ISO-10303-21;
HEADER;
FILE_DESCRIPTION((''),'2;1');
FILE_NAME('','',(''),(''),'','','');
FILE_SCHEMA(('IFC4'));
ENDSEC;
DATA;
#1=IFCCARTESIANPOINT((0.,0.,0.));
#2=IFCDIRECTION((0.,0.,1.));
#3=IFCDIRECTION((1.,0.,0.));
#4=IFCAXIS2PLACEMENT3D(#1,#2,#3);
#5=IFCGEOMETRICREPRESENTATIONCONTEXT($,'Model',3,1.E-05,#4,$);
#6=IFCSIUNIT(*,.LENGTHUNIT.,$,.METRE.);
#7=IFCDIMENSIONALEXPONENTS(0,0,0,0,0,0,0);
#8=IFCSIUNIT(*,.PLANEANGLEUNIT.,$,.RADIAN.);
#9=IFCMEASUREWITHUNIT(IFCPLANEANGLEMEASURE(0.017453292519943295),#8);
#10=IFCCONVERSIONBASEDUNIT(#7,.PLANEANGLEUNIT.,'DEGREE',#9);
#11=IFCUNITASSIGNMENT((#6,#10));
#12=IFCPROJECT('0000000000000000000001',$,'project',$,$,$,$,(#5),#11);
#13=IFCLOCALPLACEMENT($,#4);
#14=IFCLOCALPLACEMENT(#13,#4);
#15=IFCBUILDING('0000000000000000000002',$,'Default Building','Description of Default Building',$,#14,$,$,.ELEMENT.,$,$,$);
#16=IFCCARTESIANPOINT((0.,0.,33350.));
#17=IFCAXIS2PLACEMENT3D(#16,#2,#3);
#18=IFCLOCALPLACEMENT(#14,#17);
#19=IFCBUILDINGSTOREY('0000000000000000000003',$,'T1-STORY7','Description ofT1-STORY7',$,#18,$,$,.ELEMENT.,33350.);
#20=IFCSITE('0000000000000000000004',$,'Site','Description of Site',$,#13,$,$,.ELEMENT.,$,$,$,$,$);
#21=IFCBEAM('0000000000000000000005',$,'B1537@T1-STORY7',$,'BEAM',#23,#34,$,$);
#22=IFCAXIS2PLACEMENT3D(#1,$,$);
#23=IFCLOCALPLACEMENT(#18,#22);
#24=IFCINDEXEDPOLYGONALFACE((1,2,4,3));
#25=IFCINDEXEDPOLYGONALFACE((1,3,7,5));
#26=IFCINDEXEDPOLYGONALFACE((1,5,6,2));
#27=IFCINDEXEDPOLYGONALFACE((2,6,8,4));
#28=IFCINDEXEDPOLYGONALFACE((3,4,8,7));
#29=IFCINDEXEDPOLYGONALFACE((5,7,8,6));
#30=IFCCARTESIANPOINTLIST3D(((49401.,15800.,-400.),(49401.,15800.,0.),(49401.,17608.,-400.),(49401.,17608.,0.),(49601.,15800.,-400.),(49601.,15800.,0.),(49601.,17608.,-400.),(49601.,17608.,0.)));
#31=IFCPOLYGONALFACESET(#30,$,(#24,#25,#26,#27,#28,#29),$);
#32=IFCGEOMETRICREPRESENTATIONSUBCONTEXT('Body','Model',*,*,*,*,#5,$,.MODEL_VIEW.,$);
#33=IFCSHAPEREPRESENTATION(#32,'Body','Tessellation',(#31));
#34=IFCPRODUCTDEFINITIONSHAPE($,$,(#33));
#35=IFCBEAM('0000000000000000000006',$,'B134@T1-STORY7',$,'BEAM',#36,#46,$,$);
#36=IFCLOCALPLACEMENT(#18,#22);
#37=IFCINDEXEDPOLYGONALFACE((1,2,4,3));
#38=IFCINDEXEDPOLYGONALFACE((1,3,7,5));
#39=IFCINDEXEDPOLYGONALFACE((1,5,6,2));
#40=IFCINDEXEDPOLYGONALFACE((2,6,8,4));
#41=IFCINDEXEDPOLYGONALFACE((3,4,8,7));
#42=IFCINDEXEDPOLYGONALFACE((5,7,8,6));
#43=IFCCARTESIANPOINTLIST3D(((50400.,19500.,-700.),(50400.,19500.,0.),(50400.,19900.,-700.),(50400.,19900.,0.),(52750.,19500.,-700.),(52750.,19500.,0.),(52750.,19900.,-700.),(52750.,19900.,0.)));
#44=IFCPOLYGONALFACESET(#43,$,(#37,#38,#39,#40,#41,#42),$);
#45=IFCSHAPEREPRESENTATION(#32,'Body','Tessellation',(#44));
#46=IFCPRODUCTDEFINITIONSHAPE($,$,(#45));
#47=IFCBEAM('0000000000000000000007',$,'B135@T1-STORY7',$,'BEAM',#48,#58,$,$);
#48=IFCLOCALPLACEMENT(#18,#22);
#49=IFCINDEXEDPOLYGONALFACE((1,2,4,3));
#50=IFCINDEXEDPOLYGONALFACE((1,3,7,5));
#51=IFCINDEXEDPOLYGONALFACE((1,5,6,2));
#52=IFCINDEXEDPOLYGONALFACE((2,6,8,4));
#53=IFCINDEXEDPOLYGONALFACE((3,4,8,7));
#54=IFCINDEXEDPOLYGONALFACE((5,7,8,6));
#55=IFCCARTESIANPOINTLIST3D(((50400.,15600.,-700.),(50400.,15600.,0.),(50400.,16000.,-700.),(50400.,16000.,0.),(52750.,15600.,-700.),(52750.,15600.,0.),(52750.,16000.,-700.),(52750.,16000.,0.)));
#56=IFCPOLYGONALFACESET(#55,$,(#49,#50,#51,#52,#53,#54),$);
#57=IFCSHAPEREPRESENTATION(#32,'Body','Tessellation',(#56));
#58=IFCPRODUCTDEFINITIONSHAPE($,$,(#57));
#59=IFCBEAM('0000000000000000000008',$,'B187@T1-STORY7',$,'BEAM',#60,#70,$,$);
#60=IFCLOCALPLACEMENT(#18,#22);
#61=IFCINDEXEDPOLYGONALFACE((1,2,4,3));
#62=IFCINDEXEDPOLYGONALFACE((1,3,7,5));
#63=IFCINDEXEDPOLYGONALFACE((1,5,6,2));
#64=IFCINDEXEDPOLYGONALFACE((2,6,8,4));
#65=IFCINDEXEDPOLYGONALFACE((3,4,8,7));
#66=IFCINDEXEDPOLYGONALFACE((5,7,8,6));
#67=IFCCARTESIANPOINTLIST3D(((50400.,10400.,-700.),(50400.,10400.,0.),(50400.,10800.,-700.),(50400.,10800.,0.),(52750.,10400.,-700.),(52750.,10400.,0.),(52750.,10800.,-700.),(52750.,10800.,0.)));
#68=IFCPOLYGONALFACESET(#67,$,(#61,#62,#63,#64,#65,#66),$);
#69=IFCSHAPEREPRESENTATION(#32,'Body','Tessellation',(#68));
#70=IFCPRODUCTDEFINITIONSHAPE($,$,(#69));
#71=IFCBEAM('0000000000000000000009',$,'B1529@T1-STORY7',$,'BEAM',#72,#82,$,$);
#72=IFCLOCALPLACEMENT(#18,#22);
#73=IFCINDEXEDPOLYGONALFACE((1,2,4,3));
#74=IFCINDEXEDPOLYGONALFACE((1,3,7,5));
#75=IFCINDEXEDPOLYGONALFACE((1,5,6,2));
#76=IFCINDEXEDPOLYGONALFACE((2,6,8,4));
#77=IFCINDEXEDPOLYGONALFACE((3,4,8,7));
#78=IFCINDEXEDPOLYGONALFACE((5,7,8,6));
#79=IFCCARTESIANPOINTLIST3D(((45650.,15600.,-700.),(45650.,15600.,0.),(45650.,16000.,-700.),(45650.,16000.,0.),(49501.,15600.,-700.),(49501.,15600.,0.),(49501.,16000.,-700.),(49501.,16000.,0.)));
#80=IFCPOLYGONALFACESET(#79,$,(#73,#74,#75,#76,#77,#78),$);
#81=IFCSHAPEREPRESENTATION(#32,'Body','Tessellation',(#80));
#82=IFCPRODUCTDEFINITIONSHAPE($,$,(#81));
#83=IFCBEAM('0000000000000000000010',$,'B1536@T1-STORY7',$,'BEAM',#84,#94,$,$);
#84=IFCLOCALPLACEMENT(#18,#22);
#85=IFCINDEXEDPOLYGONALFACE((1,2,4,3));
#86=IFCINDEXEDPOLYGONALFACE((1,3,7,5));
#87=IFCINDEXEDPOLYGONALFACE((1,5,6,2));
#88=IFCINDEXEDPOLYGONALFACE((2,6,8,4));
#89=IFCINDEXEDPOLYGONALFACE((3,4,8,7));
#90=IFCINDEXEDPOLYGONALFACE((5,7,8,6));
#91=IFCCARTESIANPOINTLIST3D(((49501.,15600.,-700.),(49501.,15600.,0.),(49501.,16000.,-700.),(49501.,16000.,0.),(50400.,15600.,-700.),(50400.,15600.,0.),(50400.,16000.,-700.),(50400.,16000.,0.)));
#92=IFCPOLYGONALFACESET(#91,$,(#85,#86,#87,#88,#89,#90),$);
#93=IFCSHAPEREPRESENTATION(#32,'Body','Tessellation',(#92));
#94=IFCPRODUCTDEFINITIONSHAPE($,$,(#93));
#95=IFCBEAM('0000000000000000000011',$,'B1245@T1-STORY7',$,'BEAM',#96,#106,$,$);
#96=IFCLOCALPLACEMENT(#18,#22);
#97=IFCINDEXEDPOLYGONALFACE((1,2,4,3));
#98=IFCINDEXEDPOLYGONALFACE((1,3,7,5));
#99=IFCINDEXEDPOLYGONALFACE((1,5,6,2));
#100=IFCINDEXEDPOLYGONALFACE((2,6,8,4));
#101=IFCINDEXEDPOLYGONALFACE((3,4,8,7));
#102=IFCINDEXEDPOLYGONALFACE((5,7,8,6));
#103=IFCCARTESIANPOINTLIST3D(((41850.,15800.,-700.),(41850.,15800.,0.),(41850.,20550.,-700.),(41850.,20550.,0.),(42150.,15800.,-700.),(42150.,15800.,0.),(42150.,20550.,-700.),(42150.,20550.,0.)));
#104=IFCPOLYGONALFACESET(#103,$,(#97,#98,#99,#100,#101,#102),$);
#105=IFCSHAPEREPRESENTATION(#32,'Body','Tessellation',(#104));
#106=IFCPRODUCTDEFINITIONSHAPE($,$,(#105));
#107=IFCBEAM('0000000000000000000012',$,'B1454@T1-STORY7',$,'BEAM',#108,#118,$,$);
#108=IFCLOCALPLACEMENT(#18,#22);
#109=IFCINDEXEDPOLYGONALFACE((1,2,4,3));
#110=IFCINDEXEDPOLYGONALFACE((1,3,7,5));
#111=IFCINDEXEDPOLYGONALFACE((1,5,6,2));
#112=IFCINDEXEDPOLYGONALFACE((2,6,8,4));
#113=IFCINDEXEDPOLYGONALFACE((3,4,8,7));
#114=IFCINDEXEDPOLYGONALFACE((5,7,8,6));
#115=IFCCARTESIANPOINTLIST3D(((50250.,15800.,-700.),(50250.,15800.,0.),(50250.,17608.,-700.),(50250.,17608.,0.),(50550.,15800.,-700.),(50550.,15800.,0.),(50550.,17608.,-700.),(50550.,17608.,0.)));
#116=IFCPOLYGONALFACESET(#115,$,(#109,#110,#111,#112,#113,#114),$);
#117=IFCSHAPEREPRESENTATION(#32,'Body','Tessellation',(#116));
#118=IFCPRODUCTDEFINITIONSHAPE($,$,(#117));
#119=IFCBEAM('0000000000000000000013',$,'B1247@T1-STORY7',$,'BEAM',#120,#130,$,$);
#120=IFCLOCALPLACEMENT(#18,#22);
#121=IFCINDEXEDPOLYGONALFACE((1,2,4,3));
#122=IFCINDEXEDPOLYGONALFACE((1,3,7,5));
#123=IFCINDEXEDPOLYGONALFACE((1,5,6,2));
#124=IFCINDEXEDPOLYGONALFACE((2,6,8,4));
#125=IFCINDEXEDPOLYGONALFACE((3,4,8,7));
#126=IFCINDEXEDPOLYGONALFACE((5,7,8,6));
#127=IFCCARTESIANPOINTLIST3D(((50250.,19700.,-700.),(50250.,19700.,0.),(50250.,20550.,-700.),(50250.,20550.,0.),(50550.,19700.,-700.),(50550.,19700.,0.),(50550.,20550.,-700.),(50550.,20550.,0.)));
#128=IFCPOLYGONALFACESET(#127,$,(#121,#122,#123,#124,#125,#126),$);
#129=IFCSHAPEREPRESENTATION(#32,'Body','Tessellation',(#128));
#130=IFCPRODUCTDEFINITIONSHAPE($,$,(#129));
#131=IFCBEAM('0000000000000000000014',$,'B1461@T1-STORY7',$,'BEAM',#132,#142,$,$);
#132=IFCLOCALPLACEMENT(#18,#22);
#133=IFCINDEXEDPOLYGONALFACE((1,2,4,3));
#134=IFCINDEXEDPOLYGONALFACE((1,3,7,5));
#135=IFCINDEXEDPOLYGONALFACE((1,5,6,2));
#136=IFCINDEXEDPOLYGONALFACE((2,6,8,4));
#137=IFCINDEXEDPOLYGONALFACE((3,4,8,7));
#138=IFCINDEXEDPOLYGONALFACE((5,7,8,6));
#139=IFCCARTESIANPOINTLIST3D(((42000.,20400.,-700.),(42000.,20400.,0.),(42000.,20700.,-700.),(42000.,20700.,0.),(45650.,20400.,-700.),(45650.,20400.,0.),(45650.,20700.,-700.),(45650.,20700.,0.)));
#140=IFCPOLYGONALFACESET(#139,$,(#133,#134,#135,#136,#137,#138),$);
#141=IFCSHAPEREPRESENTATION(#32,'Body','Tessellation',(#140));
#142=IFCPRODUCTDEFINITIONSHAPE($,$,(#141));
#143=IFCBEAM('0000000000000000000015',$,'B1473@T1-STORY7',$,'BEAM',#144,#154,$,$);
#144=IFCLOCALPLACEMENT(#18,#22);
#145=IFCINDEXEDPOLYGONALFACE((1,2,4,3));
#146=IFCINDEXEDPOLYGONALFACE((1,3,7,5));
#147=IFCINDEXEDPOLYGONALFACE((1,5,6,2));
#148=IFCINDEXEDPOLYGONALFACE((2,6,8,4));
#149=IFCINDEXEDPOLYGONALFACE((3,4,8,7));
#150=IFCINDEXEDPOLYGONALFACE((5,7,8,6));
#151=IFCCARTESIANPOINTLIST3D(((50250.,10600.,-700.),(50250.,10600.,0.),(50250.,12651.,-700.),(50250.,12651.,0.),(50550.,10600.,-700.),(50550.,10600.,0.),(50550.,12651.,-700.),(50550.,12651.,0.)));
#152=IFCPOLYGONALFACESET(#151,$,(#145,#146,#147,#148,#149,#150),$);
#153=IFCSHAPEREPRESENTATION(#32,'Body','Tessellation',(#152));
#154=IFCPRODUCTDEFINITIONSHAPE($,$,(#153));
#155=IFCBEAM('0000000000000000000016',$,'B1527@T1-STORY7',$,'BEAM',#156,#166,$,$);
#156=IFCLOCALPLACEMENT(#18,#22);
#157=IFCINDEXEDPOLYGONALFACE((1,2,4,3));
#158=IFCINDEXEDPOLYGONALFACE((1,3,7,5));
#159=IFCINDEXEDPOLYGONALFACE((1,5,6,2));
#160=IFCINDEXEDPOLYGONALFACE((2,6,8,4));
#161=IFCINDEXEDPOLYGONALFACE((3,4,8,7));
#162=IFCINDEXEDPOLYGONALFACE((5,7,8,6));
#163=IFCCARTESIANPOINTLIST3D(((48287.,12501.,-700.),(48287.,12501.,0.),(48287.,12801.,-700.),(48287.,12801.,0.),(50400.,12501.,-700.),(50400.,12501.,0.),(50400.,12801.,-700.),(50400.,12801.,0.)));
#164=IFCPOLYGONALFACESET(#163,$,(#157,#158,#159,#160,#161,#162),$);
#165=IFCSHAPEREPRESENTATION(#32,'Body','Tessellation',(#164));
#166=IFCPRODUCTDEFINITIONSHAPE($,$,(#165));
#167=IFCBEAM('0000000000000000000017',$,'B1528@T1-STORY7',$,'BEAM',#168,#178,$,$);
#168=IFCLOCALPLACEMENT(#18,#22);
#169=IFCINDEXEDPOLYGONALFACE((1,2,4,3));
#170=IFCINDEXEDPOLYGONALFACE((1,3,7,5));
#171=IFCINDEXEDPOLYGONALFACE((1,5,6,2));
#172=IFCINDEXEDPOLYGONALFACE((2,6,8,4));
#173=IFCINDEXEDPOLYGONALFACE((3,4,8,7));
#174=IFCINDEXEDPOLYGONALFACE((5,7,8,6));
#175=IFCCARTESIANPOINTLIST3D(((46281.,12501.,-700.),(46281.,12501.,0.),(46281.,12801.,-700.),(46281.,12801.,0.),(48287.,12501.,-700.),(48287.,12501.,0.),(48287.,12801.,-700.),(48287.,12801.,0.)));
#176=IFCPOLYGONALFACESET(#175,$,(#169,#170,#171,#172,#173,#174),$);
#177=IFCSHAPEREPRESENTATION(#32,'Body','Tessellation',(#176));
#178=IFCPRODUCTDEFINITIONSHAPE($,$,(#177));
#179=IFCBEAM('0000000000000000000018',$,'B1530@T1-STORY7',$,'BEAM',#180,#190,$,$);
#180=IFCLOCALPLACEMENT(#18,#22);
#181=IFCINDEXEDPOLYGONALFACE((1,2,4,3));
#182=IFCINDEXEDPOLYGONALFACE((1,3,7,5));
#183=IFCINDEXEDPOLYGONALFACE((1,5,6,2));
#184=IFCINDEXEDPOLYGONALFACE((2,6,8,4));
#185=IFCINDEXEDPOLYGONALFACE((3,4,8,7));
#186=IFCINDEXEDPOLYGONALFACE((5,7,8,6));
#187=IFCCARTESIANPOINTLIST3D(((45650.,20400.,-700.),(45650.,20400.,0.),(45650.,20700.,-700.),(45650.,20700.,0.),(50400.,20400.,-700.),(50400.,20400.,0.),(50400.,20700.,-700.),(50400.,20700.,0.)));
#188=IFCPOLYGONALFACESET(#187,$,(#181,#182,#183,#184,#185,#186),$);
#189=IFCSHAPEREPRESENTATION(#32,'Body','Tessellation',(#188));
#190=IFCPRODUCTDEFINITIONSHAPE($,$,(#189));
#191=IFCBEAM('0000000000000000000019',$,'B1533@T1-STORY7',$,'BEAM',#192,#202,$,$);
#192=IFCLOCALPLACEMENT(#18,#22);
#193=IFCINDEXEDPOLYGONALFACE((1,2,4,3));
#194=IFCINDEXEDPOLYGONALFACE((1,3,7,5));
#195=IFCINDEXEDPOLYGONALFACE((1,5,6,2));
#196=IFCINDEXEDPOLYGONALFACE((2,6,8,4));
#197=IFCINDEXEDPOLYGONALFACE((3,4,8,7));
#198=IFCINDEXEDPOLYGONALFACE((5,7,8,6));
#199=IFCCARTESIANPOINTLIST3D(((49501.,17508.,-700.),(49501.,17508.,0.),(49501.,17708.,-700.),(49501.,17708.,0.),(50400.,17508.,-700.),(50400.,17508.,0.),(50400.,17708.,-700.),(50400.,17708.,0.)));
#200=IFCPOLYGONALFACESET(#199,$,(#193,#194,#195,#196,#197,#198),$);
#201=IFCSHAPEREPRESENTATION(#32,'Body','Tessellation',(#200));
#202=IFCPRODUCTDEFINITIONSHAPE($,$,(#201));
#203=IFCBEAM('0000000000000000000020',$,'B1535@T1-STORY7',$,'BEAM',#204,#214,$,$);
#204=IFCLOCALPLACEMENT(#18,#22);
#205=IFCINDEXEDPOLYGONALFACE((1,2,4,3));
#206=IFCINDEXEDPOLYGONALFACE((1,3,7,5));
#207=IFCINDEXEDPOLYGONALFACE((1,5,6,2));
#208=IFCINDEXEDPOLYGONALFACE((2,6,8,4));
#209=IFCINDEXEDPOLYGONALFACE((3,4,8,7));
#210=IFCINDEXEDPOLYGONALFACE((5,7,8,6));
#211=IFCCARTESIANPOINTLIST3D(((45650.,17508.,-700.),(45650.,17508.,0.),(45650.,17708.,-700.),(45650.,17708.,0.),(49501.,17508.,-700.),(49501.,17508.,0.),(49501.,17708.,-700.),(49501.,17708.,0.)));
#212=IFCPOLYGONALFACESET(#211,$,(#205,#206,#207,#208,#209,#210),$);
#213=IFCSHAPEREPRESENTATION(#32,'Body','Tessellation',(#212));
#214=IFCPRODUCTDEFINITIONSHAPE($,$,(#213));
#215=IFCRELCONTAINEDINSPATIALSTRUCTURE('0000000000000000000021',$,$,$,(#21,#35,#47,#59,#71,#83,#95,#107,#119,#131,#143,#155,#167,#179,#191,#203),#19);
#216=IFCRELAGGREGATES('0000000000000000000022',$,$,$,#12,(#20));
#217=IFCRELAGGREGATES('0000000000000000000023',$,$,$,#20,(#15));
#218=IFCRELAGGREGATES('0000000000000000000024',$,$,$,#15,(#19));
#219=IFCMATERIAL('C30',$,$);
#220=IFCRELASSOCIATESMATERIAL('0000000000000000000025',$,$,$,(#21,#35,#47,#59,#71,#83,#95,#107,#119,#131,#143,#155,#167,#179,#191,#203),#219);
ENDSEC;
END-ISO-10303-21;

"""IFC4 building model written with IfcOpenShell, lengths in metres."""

from ifc_helpers import new_model, entity, si_unit, converted_unit, frame, origin_with_axes, place, context, subcontext, project, spatial, rectangle, extrude, material, element, save


model = new_model("IFC4")

# Units and contexts
model_context = context("Model", 3, precision=1e-05, world=origin_with_axes())
body_context = subcontext(model_context, "Body", "Model", "MODEL_VIEW")
ifc_project = project(units=[si_unit("LENGTHUNIT", "METRE"), converted_unit("PLANEANGLEUNIT", "DEGREE", entity("IfcPlaneAngleMeasure", 0.017453292519943295), si_unit("PLANEANGLEUNIT", "RADIAN"), dimensions=[0, 0, 0, 0, 0, 0, 0])], contexts=[model_context])

# Site, building, storey
site_placement = place(None, origin_with_axes())
site = spatial("IfcSite", under=ifc_project, at=site_placement, Name="Site", Description="Description of Site", CompositionType="ELEMENT")
building_placement = place(site_placement, origin_with_axes())
building = spatial("IfcBuilding", under=site, at=building_placement, Name="Default Building", Description="Description of Default Building", CompositionType="ELEMENT")
storey_placement = place(building_placement, frame((0.0, 0.0, 33350.0), z_axis=(0.0, 0.0, 1.0), x_axis=(1.0, 0.0, 0.0)))
storey = spatial("IfcBuildingStorey", under=building, at=storey_placement, Name="T1-STORY7", Description="Description ofT1-STORY7", CompositionType="ELEMENT", Elevation=33350.0)

# Beams
ifc_material_1 = material(Name="C30")
beam_1_placement = place(storey_placement, frame((49501.0, 15800.0, -200.0), z_axis=(0.0, 1.0, 0.0), x_axis=(-1.0, 0.0, 0.0)))
element("IfcBeam", 1, at=beam_1_placement, inside=storey, material=ifc_material_1, Name="B1537@T1-STORY7", ObjectType="BEAM", context=body_context, shape_type="SweptSolid", body=[
    extrude(rectangle(XDim=200.0, YDim=400.0), origin_with_axes(), (0.0, 0.0, 1.0), 1808.0),
])
for number, where, z_axis, x_axis, name in (
    (2, (50400.0, 19700.0, -350.0), (1.0, 0.0, 0.0), (0.0, 1.0, 0.0), "B134@T1-STORY7"),
    (3, (50400.0, 15800.0, -350.0), (1.0, 0.0, 0.0), (0.0, 1.0, 0.0), "B135@T1-STORY7"),
    (4, (50400.0, 10600.0, -350.0), (1.0, 0.0, 0.0), (0.0, 1.0, 0.0), "B187@T1-STORY7"),
):
    element("IfcBeam", number, at=place(storey_placement, frame(where, z_axis=z_axis, x_axis=x_axis)), inside=storey, material=ifc_material_1, Name=name, ObjectType="BEAM", context=body_context, shape_type="SweptSolid", body=[
        extrude(rectangle(XDim=400.0, YDim=700.0), origin_with_axes(), (0.0, 0.0, 1.0), 2350.0),
    ])
beam_2_placement = place(storey_placement, frame((45650.0, 15800.0, -350.0), z_axis=(1.0, 0.0, 0.0), x_axis=(0.0, 1.0, 0.0)))
element("IfcBeam", 5, at=beam_2_placement, inside=storey, material=ifc_material_1, Name="B1529@T1-STORY7", ObjectType="BEAM", context=body_context, shape_type="SweptSolid", body=[
    extrude(rectangle(XDim=400.0, YDim=700.0), origin_with_axes(), (0.0, 0.0, 1.0), 3851.0),
])
beam_3_placement = place(storey_placement, frame((49501.0, 15800.0, -350.0), z_axis=(1.0, 0.0, 0.0), x_axis=(0.0, 1.0, 0.0)))
element("IfcBeam", 6, at=beam_3_placement, inside=storey, material=ifc_material_1, Name="B1536@T1-STORY7", ObjectType="BEAM", context=body_context, shape_type="SweptSolid", body=[
    extrude(rectangle(XDim=400.0, YDim=700.0), origin_with_axes(), (0.0, 0.0, 1.0), 899.0),
])
beam_4_placement = place(storey_placement, frame((42000.0, 15800.0, -350.0), z_axis=(0.0, 1.0, 0.0), x_axis=(-1.0, 0.0, 0.0)))
element("IfcBeam", 7, at=beam_4_placement, inside=storey, material=ifc_material_1, Name="B1245@T1-STORY7", ObjectType="BEAM", context=body_context, shape_type="SweptSolid", body=[
    extrude(rectangle(XDim=300.0, YDim=700.0), origin_with_axes(), (0.0, 0.0, 1.0), 4750.0),
])
beam_5_placement = place(storey_placement, frame((50400.0, 15800.0, -350.0), z_axis=(0.0, 1.0, 0.0), x_axis=(-1.0, 0.0, 0.0)))
element("IfcBeam", 8, at=beam_5_placement, inside=storey, material=ifc_material_1, Name="B1454@T1-STORY7", ObjectType="BEAM", context=body_context, shape_type="SweptSolid", body=[
    extrude(rectangle(XDim=300.0, YDim=700.0), origin_with_axes(), (0.0, 0.0, 1.0), 1808.0),
])
beam_6_placement = place(storey_placement, frame((50400.0, 19700.0, -350.0), z_axis=(0.0, 1.0, 0.0), x_axis=(-1.0, 0.0, 0.0)))
element("IfcBeam", 9, at=beam_6_placement, inside=storey, material=ifc_material_1, Name="B1247@T1-STORY7", ObjectType="BEAM", context=body_context, shape_type="SweptSolid", body=[
    extrude(rectangle(XDim=300.0, YDim=700.0), origin_with_axes(), (0.0, 0.0, 1.0), 850.0),
])
beam_7_placement = place(storey_placement, frame((42000.0, 20550.0, -350.0), z_axis=(1.0, 0.0, 0.0), x_axis=(0.0, 1.0, 0.0)))
element("IfcBeam", 10, at=beam_7_placement, inside=storey, material=ifc_material_1, Name="B1461@T1-STORY7", ObjectType="BEAM", context=body_context, shape_type="SweptSolid", body=[
    extrude(rectangle(XDim=300.0, YDim=700.0), origin_with_axes(), (0.0, 0.0, 1.0), 3650.0),
])
beam_8_placement = place(storey_placement, frame((50400.0, 10600.0, -350.0), z_axis=(0.0, 1.0, 0.0), x_axis=(-1.0, 0.0, 0.0)))
element("IfcBeam", 11, at=beam_8_placement, inside=storey, material=ifc_material_1, Name="B1473@T1-STORY7", ObjectType="BEAM", context=body_context, shape_type="SweptSolid", body=[
    extrude(rectangle(XDim=300.0, YDim=700.0), origin_with_axes(), (0.0, 0.0, 1.0), 2051.0),
])
beam_9_placement = place(storey_placement, frame((48287.0, 12651.0, -350.0), z_axis=(1.0, 0.0, 0.0), x_axis=(0.0, 1.0, 0.0)))
element("IfcBeam", 12, at=beam_9_placement, inside=storey, material=ifc_material_1, Name="B1527@T1-STORY7", ObjectType="BEAM", context=body_context, shape_type="SweptSolid", body=[
    extrude(rectangle(XDim=300.0, YDim=700.0), origin_with_axes(), (0.0, 0.0, 1.0), 2113.0),
])
beam_10_placement = place(storey_placement, frame((46281.0, 12651.0, -350.0), z_axis=(1.0, 0.0, 0.0), x_axis=(0.0, 1.0, 0.0)))
element("IfcBeam", 13, at=beam_10_placement, inside=storey, material=ifc_material_1, Name="B1528@T1-STORY7", ObjectType="BEAM", context=body_context, shape_type="SweptSolid", body=[
    extrude(rectangle(XDim=300.0, YDim=700.0), origin_with_axes(), (0.0, 0.0, 1.0), 2006.0),
])
beam_11_placement = place(storey_placement, frame((45650.0, 20550.0, -350.0), z_axis=(1.0, 0.0, 0.0), x_axis=(0.0, 1.0, 0.0)))
element("IfcBeam", 14, at=beam_11_placement, inside=storey, material=ifc_material_1, Name="B1530@T1-STORY7", ObjectType="BEAM", context=body_context, shape_type="SweptSolid", body=[
    extrude(rectangle(XDim=300.0, YDim=700.0), origin_with_axes(), (0.0, 0.0, 1.0), 4750.0),
])
beam_12_placement = place(storey_placement, frame((49501.0, 17608.0, -350.0), z_axis=(1.0, 0.0, 0.0), x_axis=(0.0, 1.0, 0.0)))
element("IfcBeam", 15, at=beam_12_placement, inside=storey, material=ifc_material_1, Name="B1533@T1-STORY7", ObjectType="BEAM", context=body_context, shape_type="SweptSolid", body=[
    extrude(rectangle(XDim=200.0, YDim=700.0), origin_with_axes(), (0.0, 0.0, 1.0), 899.0),
])
beam_13_placement = place(storey_placement, frame((45650.0, 17608.0, -350.0), z_axis=(1.0, 0.0, 0.0), x_axis=(0.0, 1.0, 0.0)))
element("IfcBeam", 16, at=beam_13_placement, inside=storey, material=ifc_material_1, Name="B1535@T1-STORY7", ObjectType="BEAM", context=body_context, shape_type="SweptSolid", body=[
    extrude(rectangle(XDim=200.0, YDim=700.0), origin_with_axes(), (0.0, 0.0, 1.0), 3851.0),
])

save(model, "model.ifc")
